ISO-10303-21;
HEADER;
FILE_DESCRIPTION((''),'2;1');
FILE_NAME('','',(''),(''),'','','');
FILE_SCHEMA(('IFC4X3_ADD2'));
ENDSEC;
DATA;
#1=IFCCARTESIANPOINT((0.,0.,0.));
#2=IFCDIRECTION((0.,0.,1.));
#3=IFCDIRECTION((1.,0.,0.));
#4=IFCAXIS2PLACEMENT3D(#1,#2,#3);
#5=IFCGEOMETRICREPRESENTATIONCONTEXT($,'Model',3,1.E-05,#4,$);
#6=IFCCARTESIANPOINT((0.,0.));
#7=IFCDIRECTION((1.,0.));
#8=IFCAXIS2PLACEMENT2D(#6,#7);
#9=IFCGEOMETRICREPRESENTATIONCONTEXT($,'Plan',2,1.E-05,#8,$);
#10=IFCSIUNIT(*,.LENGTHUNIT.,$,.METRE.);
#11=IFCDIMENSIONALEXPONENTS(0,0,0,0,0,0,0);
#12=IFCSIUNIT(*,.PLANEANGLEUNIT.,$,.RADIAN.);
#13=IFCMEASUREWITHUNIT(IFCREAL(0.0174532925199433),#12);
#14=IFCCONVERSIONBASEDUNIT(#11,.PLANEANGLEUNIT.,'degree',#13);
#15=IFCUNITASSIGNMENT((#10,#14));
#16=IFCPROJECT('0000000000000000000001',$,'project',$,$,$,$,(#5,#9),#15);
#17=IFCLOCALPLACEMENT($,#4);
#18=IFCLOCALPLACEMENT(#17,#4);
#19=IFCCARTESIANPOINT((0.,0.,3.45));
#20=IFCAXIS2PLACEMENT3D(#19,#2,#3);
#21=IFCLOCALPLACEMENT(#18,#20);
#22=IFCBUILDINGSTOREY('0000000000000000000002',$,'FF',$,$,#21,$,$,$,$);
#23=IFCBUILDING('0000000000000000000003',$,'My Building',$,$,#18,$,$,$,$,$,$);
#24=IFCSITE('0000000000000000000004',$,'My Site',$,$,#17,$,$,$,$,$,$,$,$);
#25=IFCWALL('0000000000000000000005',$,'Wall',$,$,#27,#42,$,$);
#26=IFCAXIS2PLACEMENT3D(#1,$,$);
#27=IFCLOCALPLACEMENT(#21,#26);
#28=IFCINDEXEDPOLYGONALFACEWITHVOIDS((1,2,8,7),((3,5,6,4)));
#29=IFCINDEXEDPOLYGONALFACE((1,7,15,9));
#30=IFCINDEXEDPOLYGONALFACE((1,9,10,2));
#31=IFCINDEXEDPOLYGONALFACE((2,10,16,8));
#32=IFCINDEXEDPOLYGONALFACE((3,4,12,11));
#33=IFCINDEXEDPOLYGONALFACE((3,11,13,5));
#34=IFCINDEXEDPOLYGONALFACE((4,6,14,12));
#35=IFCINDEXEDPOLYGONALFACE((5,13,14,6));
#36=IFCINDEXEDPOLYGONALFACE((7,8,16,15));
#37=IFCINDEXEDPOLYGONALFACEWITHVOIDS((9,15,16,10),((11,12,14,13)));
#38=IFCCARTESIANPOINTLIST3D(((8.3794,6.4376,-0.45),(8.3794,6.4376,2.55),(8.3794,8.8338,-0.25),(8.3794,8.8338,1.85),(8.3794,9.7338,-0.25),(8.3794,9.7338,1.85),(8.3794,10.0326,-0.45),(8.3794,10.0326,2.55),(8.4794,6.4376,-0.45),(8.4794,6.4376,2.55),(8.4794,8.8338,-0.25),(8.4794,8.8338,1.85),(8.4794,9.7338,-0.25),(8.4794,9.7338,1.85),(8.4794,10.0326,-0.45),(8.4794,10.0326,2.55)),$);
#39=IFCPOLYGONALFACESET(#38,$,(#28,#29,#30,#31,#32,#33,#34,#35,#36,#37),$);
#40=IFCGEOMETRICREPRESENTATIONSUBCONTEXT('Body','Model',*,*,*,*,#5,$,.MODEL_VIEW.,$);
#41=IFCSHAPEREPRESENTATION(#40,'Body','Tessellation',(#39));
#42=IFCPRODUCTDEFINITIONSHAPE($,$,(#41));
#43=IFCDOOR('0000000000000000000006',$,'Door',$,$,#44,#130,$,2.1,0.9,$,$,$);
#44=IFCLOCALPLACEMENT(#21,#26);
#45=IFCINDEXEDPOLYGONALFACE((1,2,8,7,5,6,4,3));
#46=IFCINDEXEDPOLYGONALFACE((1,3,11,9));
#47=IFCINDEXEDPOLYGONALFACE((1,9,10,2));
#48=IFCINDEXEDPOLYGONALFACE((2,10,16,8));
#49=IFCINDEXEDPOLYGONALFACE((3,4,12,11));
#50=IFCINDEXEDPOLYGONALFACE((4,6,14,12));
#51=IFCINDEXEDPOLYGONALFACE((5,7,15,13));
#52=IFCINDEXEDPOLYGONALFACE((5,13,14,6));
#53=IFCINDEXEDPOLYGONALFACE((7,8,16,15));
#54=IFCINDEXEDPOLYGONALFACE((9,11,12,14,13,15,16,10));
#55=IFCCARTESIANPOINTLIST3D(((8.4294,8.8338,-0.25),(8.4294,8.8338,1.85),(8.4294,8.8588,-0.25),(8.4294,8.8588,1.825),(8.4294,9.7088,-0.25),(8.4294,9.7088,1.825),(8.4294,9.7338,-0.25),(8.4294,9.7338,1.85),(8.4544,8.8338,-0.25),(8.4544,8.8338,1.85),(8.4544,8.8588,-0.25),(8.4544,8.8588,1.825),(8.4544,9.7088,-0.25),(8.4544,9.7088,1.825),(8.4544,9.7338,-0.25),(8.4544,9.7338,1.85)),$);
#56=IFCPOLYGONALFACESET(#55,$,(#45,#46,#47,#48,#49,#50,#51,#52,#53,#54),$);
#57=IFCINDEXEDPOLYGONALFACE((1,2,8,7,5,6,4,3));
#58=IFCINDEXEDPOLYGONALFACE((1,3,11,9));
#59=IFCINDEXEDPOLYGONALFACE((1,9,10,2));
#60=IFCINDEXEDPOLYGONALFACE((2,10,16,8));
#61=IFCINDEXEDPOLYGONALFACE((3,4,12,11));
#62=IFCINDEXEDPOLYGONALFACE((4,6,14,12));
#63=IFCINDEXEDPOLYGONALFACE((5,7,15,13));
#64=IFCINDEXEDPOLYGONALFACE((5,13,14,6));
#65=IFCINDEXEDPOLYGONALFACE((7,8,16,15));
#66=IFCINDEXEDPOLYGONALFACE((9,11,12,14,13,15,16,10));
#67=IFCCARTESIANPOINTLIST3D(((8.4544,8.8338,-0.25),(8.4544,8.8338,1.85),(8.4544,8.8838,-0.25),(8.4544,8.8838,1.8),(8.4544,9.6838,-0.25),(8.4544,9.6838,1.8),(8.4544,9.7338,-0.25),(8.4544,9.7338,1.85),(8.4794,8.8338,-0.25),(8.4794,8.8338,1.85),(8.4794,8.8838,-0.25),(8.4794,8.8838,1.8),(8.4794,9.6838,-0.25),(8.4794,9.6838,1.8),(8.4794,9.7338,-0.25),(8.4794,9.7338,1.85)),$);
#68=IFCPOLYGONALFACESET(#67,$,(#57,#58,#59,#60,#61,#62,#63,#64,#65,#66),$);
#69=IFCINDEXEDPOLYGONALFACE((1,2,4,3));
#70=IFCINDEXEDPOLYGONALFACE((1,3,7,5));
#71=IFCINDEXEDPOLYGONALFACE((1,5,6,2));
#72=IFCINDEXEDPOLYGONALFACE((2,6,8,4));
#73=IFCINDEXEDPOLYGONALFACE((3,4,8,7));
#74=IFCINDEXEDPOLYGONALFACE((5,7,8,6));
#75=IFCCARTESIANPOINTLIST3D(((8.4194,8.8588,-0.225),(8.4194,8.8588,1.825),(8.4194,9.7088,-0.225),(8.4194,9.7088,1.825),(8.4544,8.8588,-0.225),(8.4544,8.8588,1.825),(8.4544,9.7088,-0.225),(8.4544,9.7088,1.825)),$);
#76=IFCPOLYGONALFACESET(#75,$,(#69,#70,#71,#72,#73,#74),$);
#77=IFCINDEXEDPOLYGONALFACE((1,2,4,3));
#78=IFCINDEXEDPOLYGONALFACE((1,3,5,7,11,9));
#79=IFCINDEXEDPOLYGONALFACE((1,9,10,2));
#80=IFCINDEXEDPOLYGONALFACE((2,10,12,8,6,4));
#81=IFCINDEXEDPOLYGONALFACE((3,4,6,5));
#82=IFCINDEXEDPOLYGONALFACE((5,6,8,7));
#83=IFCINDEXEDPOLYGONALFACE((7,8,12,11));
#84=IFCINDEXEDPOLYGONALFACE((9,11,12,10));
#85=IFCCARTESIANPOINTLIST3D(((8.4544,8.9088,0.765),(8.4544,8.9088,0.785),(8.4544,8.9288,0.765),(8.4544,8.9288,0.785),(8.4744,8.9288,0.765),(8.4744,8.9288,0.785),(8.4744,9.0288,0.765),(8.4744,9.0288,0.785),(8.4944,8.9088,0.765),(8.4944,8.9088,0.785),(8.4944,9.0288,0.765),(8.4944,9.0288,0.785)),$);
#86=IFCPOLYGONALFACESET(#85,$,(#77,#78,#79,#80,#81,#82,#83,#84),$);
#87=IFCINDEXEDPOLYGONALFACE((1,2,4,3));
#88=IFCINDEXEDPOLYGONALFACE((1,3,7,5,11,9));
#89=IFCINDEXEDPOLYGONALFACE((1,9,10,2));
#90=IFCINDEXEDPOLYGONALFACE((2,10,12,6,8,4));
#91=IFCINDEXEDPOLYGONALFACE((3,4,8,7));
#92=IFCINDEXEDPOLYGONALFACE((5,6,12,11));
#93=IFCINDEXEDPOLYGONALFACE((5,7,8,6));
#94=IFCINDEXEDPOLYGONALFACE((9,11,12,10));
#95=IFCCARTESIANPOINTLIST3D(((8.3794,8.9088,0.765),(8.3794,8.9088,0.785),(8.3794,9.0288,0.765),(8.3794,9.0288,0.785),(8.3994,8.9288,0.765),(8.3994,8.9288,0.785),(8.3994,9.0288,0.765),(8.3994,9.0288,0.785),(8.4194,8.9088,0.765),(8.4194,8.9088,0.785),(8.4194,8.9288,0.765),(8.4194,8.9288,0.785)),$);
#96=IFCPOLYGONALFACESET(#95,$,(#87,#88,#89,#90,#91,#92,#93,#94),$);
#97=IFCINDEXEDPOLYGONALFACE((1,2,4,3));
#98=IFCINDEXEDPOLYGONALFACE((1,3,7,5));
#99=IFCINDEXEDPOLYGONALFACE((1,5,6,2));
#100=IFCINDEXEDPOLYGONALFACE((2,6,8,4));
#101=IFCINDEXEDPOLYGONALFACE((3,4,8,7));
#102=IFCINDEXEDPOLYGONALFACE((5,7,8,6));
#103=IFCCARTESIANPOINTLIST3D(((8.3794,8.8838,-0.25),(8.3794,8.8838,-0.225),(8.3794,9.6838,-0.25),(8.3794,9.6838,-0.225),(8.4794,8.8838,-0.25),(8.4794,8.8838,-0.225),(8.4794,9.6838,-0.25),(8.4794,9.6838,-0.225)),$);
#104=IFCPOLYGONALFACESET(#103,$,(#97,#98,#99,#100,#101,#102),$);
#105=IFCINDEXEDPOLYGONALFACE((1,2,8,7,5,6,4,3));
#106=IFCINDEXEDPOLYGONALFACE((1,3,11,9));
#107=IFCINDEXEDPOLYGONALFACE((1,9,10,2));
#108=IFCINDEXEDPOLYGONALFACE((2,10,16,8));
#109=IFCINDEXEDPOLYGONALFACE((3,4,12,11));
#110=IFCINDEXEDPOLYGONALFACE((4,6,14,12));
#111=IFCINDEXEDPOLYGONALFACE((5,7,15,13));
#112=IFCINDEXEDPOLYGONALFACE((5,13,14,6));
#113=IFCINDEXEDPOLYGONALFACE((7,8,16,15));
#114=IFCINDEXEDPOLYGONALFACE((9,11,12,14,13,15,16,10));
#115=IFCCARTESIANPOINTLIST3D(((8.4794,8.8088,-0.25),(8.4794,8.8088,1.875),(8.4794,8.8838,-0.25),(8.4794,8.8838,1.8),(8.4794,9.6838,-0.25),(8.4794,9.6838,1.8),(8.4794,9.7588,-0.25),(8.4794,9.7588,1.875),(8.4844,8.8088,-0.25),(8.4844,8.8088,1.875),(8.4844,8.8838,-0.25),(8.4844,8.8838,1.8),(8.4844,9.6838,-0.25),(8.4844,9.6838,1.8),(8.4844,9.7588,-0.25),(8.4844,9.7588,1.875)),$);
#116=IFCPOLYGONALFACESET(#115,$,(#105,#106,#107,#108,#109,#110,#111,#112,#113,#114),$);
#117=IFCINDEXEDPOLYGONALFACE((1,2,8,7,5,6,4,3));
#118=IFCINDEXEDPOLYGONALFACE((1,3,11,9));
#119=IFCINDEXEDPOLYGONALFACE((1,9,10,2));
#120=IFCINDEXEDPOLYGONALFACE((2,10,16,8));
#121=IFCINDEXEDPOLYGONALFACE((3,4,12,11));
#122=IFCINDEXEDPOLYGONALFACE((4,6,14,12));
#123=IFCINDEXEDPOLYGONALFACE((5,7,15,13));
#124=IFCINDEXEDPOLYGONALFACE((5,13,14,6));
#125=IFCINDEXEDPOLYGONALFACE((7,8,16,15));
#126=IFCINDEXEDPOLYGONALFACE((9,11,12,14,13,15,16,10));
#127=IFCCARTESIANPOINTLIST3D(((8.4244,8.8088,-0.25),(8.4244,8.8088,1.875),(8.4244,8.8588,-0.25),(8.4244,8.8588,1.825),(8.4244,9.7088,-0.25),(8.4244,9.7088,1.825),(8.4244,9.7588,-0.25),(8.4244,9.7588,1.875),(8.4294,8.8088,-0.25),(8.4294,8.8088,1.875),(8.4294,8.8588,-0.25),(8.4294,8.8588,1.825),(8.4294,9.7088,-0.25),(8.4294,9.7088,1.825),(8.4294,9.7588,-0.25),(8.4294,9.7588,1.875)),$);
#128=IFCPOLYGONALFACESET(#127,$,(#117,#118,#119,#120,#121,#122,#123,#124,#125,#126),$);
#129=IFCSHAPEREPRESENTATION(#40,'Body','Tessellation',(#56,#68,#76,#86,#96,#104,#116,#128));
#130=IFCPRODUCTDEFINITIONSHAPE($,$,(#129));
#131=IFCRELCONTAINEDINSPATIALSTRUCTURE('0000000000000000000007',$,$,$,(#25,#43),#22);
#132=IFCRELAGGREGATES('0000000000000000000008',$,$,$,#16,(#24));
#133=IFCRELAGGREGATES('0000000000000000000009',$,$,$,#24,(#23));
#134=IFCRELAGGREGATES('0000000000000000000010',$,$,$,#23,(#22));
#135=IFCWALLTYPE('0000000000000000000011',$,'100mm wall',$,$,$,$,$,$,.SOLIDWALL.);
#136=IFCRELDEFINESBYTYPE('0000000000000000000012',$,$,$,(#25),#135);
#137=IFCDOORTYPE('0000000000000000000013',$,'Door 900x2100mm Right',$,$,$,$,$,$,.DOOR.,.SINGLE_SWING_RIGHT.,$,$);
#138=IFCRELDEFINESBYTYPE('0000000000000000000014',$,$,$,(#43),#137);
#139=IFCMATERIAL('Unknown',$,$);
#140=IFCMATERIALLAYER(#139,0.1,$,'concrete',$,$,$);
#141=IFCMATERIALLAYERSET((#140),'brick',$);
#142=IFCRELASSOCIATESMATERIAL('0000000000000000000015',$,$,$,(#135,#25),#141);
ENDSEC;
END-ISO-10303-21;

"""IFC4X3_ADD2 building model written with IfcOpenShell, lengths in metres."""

from ifc_helpers import new_model, entity, si_unit, converted_unit, frame, origin_with_axes, origin_2d_with_axis, place, context, subcontext, project, spatial, line, indexed_curve, outline, extrude, shape, source, transform, mapped, material, layer, layer_set, layer_usage, type_object, type_shapes, element, fill, save


model = new_model("IFC4X3_ADD2")

# Units and contexts
model_context = context("Model", 3, precision=1e-05, world=origin_with_axes())
plan_context = context("Plan", 2, precision=1e-05, world=origin_2d_with_axis())
body_context_1 = subcontext(model_context, "Body", "Model", "MODEL_VIEW")
body_context_2 = subcontext(plan_context, "Body", "Plan", "PLAN_VIEW")
ifc_project = project(units=[si_unit("LENGTHUNIT", "METRE"), converted_unit("PLANEANGLEUNIT", "degree", entity("IfcReal", 0.0174532925199433), si_unit("PLANEANGLEUNIT", "RADIAN"), dimensions=[0, 0, 0, 0, 0, 0, 0])], contexts=[model_context, plan_context])

# Site, building, storey
site_placement = place(None, origin_with_axes())
site = spatial("IfcSite", under=ifc_project, at=site_placement, Name="My Site")
building_placement = place(site_placement, origin_with_axes())
building = spatial("IfcBuilding", under=site, at=building_placement, Name="My Building")
storey_placement = place(building_placement, frame((0.0, 0.0, 3.45), z_axis=(0.0, 0.0, 1.0), x_axis=(1.0, 0.0, 0.0)))
storey = spatial("IfcBuildingStorey", under=building, at=storey_placement, Name="FF")

# Shared definitions
ifc_material = material(Name="Unknown")

# Wall, opening, door
shared_shape_1 = source(origin_with_axes(), body_context_1, "Body", "SolidModel", [
    extrude(outline(indexed_curve([(0.0, 0.0), (0.9, 0.0), (0.9, 2.1), (0.0, 2.1)], segments=[line(1, 2, 3, 4, 1)])), frame((0.0, -0.6, 0.0), z_axis=(0.0, -1.0, 0.0), x_axis=(1.0, 0.0, 0.0)), (0.0, 0.0, -1.0), 1.2),
])
door_type_1 = type_object("IfcDoorType", Name="Door 900x2100mm Right", OperationType="SINGLE_SWING_RIGHT", PredefinedType="DOOR")
shared_shape_2 = source(origin_with_axes(), body_context_1, "Body", "SweptSolid", [
    extrude(outline(indexed_curve([(0.0, 0.0), (0.0, 2.1), (0.9, 2.1), (0.9, 0.0), (0.875, 0.0), (0.875, 2.075), (0.025, 2.075), (0.025, 0.0)], segments=[line(1, 2, 3, 4, 5, 6, 7, 8, 1)])), frame((0.0, 0.025, 0.0), z_axis=(0.0, -1.0, 0.0), x_axis=(1.0, 0.0, 0.0)), (0.0, 0.0, -1.0), 0.025),
    extrude(outline(indexed_curve([(0.0, 0.0), (0.0, 2.1), (0.9, 2.1), (0.9, 0.0), (0.85, 0.0), (0.85, 2.05), (0.05, 2.05), (0.05, 0.0)], segments=[line(1, 2, 3, 4, 5, 6, 7, 8, 1)])), frame((0.0, 0.0, 0.0), z_axis=(0.0, -1.0, 0.0), x_axis=(1.0, 0.0, 0.0)), (0.0, 0.0, -1.0), 0.025),
    extrude(outline(indexed_curve([(0.0, 0.0), (0.85, 0.0), (0.85, 0.035), (0.0, 0.035)], segments=[line(1, 2, 3, 4, 1)])), frame((0.025, 0.025, 0.025), z_axis=(0.0, 0.0, 1.0), x_axis=(1.0, 0.0, 0.0)), (0.0, 0.0, 1.0), 2.05),
    extrude(outline(indexed_curve([(0.0, 0.0), (0.0, -0.04), (0.12, -0.04), (0.12, -0.02), (0.02, -0.02), (0.02, 0.0)], segments=[line(1, 2, 3, 4, 5, 6, 1)])), frame((0.075, 0.025, 1.015), z_axis=(0.0, 0.0, 1.0), x_axis=(1.0, 0.0, 0.0)), (0.0, 0.0, 1.0), 0.02),
    extrude(outline(indexed_curve([(0.0, 0.0), (0.0, 0.04), (0.12, 0.04), (0.12, 0.02), (0.02, 0.02), (0.02, 0.0)], segments=[line(1, 2, 3, 4, 5, 6, 1)])), frame((0.075, 0.06, 1.015), z_axis=(0.0, 0.0, 1.0), x_axis=(1.0, 0.0, 0.0)), (0.0, 0.0, 1.0), 0.02),
    extrude(outline(indexed_curve([(0.0, 0.0), (0.8, 0.0), (0.8, 0.1), (0.0, 0.1)], segments=[line(1, 2, 3, 4, 1)])), frame((0.05, 0.0, 0.0), z_axis=(0.0, 0.0, 1.0), x_axis=(1.0, 0.0, 0.0)), (0.0, 0.0, 1.0), 0.025),
    extrude(outline(indexed_curve([(0.0, 0.0), (0.0, 2.125), (0.95, 2.125), (0.95, 0.0), (0.875, 0.0), (0.875, 2.05), (0.075, 2.05), (0.075, 0.0)], segments=[line(1, 2, 3, 4, 5, 6, 7, 8, 1)])), frame((-0.025, -0.005, 0.0), z_axis=(0.0, -1.0, 0.0), x_axis=(1.0, 0.0, 0.0)), (0.0, 0.0, -1.0), 0.005),
    extrude(outline(indexed_curve([(0.0, 0.0), (0.0, 2.125), (0.95, 2.125), (0.95, 0.0), (0.9, 0.0), (0.9, 2.075), (0.05, 2.075), (0.05, 0.0)], segments=[line(1, 2, 3, 4, 5, 6, 7, 8, 1)])), frame((-0.025, 0.05, 0.0), z_axis=(0.0, -1.0, 0.0), x_axis=(1.0, 0.0, 0.0)), (0.0, 0.0, -1.0), 0.005),
])
shared_shape_3 = source(origin_with_axes(), body_context_2, "Body", "Curve2D", [
    entity("IfcIndexedPolyCurve", entity("IfcCartesianPointList2D", [[0.0, 0.0], [0.0, 0.05], [0.025, 0.05], [0.025, 0.025], [0.05, 0.025], [0.05, 0.0]]), [entity("IfcLineIndex", [1, 2, 3, 4, 5, 6, 1])]),
    entity("IfcIndexedPolyCurve", entity("IfcCartesianPointList2D", [[0.9, 0.0], [0.9, 0.05], [0.875, 0.05], [0.875, 0.025], [0.85, 0.025], [0.85, 0.0]]), [entity("IfcLineIndex", [1, 2, 3, 4, 5, 6, 1])]),
    entity("IfcTrimmedCurve", entity("IfcEllipse", entity("IfcAxis2Placement2D", entity("IfcCartesianPoint", [0.84, 0.05]), entity("IfcDirection", [1.0, 0.0])), 0.815, 0.85), [entity("IfcCartesianPoint", [0.84, 0.9])], [entity("IfcCartesianPoint", [0.025, 0.05])], True, "CARTESIAN"),
    entity("IfcIndexedPolyCurve", entity("IfcCartesianPointList2D", [[0.875, 0.05], [0.84, 0.05], [0.84, 0.9], [0.875, 0.9]]), [entity("IfcLineIndex", [1, 2, 3, 4, 1])]),
])
type_shapes(door_type_1, [shared_shape_2, shared_shape_3])
ifc_layer_1 = layer(ifc_material, 0.1, Name="concrete")
ifc_layer_set_1 = layer_set([ifc_layer_1], Name="brick")
ifc_layer_usage_1 = layer_usage(ifc_layer_set_1, "AXIS2", "POSITIVE", 0.0)
wall_type_1 = type_object("IfcWallType", Name="100mm wall", PredefinedType="SOLIDWALL", material=ifc_layer_set_1)
wall_1_placement = place(storey_placement, frame((8.4794, 6.4376, -0.45), z_axis=(0.0, 0.0, 1.0), x_axis=(0.0, 1.0, 0.0)))
wall_1 = element("IfcWall", 1, at=wall_1_placement, inside=storey, type_object=wall_type_1, material=ifc_layer_usage_1, Name="Wall", context=body_context_1, shape_type="SweptSolid", body=[
    extrude(outline(indexed_curve([(0.0, 0.0), (0.0, 0.1), (3.595, 0.1), (3.595, 0.0)], segments=[line(1, 2, 3, 4, 1)])), origin_with_axes(), (0.0, 0.0, 1.0), 3.0),
])
opening_1_placement = place(wall_1_placement, frame((2.3963, 0.0, 0.2), z_axis=(0.0, 0.0, 1.0), x_axis=(1.0, 0.0, 0.0)))
opening_1 = element("IfcOpeningElement", 2, at=opening_1_placement, cuts=wall_1, PredefinedType="OPENING", context=body_context_1, shape_type="MappedRepresentation", body=[
    mapped(shared_shape_1, transform((0.0, 0.0, 0.0), x_axis=(1.0, 0.0, 0.0), y_axis=(0.0, 1.0, 0.0), z_axis=(0.0, 0.0, 1.0), scale=1.0)),
])
door_1_placement = place(opening_1_placement, frame((0.0, 0.0, 0.0), z_axis=(0.0, 0.0, 1.0), x_axis=(1.0, 0.0, 0.0)))
door_1 = element("IfcDoor", 3, at=door_1_placement, inside=storey, type_object=door_type_1, Name="Door", OverallHeight=2.1, OverallWidth=0.9, shapes=[
    shape(body_context_1, "Body", "MappedRepresentation", [mapped(shared_shape_2, transform((0.0, 0.0, 0.0), x_axis=(1.0, 0.0, 0.0), y_axis=(0.0, 1.0, 0.0), z_axis=(0.0, 0.0, 1.0), scale=1.0))]),
    shape(body_context_2, "Body", "MappedRepresentation", [mapped(shared_shape_3, transform((0.0, 0.0, 0.0), x_axis=(1.0, 0.0, 0.0), y_axis=(0.0, 1.0, 0.0), z_axis=(0.0, 0.0, 1.0), scale=1.0))]),
])
fill(opening_1, door_1)

save(model, "model.ifc")
